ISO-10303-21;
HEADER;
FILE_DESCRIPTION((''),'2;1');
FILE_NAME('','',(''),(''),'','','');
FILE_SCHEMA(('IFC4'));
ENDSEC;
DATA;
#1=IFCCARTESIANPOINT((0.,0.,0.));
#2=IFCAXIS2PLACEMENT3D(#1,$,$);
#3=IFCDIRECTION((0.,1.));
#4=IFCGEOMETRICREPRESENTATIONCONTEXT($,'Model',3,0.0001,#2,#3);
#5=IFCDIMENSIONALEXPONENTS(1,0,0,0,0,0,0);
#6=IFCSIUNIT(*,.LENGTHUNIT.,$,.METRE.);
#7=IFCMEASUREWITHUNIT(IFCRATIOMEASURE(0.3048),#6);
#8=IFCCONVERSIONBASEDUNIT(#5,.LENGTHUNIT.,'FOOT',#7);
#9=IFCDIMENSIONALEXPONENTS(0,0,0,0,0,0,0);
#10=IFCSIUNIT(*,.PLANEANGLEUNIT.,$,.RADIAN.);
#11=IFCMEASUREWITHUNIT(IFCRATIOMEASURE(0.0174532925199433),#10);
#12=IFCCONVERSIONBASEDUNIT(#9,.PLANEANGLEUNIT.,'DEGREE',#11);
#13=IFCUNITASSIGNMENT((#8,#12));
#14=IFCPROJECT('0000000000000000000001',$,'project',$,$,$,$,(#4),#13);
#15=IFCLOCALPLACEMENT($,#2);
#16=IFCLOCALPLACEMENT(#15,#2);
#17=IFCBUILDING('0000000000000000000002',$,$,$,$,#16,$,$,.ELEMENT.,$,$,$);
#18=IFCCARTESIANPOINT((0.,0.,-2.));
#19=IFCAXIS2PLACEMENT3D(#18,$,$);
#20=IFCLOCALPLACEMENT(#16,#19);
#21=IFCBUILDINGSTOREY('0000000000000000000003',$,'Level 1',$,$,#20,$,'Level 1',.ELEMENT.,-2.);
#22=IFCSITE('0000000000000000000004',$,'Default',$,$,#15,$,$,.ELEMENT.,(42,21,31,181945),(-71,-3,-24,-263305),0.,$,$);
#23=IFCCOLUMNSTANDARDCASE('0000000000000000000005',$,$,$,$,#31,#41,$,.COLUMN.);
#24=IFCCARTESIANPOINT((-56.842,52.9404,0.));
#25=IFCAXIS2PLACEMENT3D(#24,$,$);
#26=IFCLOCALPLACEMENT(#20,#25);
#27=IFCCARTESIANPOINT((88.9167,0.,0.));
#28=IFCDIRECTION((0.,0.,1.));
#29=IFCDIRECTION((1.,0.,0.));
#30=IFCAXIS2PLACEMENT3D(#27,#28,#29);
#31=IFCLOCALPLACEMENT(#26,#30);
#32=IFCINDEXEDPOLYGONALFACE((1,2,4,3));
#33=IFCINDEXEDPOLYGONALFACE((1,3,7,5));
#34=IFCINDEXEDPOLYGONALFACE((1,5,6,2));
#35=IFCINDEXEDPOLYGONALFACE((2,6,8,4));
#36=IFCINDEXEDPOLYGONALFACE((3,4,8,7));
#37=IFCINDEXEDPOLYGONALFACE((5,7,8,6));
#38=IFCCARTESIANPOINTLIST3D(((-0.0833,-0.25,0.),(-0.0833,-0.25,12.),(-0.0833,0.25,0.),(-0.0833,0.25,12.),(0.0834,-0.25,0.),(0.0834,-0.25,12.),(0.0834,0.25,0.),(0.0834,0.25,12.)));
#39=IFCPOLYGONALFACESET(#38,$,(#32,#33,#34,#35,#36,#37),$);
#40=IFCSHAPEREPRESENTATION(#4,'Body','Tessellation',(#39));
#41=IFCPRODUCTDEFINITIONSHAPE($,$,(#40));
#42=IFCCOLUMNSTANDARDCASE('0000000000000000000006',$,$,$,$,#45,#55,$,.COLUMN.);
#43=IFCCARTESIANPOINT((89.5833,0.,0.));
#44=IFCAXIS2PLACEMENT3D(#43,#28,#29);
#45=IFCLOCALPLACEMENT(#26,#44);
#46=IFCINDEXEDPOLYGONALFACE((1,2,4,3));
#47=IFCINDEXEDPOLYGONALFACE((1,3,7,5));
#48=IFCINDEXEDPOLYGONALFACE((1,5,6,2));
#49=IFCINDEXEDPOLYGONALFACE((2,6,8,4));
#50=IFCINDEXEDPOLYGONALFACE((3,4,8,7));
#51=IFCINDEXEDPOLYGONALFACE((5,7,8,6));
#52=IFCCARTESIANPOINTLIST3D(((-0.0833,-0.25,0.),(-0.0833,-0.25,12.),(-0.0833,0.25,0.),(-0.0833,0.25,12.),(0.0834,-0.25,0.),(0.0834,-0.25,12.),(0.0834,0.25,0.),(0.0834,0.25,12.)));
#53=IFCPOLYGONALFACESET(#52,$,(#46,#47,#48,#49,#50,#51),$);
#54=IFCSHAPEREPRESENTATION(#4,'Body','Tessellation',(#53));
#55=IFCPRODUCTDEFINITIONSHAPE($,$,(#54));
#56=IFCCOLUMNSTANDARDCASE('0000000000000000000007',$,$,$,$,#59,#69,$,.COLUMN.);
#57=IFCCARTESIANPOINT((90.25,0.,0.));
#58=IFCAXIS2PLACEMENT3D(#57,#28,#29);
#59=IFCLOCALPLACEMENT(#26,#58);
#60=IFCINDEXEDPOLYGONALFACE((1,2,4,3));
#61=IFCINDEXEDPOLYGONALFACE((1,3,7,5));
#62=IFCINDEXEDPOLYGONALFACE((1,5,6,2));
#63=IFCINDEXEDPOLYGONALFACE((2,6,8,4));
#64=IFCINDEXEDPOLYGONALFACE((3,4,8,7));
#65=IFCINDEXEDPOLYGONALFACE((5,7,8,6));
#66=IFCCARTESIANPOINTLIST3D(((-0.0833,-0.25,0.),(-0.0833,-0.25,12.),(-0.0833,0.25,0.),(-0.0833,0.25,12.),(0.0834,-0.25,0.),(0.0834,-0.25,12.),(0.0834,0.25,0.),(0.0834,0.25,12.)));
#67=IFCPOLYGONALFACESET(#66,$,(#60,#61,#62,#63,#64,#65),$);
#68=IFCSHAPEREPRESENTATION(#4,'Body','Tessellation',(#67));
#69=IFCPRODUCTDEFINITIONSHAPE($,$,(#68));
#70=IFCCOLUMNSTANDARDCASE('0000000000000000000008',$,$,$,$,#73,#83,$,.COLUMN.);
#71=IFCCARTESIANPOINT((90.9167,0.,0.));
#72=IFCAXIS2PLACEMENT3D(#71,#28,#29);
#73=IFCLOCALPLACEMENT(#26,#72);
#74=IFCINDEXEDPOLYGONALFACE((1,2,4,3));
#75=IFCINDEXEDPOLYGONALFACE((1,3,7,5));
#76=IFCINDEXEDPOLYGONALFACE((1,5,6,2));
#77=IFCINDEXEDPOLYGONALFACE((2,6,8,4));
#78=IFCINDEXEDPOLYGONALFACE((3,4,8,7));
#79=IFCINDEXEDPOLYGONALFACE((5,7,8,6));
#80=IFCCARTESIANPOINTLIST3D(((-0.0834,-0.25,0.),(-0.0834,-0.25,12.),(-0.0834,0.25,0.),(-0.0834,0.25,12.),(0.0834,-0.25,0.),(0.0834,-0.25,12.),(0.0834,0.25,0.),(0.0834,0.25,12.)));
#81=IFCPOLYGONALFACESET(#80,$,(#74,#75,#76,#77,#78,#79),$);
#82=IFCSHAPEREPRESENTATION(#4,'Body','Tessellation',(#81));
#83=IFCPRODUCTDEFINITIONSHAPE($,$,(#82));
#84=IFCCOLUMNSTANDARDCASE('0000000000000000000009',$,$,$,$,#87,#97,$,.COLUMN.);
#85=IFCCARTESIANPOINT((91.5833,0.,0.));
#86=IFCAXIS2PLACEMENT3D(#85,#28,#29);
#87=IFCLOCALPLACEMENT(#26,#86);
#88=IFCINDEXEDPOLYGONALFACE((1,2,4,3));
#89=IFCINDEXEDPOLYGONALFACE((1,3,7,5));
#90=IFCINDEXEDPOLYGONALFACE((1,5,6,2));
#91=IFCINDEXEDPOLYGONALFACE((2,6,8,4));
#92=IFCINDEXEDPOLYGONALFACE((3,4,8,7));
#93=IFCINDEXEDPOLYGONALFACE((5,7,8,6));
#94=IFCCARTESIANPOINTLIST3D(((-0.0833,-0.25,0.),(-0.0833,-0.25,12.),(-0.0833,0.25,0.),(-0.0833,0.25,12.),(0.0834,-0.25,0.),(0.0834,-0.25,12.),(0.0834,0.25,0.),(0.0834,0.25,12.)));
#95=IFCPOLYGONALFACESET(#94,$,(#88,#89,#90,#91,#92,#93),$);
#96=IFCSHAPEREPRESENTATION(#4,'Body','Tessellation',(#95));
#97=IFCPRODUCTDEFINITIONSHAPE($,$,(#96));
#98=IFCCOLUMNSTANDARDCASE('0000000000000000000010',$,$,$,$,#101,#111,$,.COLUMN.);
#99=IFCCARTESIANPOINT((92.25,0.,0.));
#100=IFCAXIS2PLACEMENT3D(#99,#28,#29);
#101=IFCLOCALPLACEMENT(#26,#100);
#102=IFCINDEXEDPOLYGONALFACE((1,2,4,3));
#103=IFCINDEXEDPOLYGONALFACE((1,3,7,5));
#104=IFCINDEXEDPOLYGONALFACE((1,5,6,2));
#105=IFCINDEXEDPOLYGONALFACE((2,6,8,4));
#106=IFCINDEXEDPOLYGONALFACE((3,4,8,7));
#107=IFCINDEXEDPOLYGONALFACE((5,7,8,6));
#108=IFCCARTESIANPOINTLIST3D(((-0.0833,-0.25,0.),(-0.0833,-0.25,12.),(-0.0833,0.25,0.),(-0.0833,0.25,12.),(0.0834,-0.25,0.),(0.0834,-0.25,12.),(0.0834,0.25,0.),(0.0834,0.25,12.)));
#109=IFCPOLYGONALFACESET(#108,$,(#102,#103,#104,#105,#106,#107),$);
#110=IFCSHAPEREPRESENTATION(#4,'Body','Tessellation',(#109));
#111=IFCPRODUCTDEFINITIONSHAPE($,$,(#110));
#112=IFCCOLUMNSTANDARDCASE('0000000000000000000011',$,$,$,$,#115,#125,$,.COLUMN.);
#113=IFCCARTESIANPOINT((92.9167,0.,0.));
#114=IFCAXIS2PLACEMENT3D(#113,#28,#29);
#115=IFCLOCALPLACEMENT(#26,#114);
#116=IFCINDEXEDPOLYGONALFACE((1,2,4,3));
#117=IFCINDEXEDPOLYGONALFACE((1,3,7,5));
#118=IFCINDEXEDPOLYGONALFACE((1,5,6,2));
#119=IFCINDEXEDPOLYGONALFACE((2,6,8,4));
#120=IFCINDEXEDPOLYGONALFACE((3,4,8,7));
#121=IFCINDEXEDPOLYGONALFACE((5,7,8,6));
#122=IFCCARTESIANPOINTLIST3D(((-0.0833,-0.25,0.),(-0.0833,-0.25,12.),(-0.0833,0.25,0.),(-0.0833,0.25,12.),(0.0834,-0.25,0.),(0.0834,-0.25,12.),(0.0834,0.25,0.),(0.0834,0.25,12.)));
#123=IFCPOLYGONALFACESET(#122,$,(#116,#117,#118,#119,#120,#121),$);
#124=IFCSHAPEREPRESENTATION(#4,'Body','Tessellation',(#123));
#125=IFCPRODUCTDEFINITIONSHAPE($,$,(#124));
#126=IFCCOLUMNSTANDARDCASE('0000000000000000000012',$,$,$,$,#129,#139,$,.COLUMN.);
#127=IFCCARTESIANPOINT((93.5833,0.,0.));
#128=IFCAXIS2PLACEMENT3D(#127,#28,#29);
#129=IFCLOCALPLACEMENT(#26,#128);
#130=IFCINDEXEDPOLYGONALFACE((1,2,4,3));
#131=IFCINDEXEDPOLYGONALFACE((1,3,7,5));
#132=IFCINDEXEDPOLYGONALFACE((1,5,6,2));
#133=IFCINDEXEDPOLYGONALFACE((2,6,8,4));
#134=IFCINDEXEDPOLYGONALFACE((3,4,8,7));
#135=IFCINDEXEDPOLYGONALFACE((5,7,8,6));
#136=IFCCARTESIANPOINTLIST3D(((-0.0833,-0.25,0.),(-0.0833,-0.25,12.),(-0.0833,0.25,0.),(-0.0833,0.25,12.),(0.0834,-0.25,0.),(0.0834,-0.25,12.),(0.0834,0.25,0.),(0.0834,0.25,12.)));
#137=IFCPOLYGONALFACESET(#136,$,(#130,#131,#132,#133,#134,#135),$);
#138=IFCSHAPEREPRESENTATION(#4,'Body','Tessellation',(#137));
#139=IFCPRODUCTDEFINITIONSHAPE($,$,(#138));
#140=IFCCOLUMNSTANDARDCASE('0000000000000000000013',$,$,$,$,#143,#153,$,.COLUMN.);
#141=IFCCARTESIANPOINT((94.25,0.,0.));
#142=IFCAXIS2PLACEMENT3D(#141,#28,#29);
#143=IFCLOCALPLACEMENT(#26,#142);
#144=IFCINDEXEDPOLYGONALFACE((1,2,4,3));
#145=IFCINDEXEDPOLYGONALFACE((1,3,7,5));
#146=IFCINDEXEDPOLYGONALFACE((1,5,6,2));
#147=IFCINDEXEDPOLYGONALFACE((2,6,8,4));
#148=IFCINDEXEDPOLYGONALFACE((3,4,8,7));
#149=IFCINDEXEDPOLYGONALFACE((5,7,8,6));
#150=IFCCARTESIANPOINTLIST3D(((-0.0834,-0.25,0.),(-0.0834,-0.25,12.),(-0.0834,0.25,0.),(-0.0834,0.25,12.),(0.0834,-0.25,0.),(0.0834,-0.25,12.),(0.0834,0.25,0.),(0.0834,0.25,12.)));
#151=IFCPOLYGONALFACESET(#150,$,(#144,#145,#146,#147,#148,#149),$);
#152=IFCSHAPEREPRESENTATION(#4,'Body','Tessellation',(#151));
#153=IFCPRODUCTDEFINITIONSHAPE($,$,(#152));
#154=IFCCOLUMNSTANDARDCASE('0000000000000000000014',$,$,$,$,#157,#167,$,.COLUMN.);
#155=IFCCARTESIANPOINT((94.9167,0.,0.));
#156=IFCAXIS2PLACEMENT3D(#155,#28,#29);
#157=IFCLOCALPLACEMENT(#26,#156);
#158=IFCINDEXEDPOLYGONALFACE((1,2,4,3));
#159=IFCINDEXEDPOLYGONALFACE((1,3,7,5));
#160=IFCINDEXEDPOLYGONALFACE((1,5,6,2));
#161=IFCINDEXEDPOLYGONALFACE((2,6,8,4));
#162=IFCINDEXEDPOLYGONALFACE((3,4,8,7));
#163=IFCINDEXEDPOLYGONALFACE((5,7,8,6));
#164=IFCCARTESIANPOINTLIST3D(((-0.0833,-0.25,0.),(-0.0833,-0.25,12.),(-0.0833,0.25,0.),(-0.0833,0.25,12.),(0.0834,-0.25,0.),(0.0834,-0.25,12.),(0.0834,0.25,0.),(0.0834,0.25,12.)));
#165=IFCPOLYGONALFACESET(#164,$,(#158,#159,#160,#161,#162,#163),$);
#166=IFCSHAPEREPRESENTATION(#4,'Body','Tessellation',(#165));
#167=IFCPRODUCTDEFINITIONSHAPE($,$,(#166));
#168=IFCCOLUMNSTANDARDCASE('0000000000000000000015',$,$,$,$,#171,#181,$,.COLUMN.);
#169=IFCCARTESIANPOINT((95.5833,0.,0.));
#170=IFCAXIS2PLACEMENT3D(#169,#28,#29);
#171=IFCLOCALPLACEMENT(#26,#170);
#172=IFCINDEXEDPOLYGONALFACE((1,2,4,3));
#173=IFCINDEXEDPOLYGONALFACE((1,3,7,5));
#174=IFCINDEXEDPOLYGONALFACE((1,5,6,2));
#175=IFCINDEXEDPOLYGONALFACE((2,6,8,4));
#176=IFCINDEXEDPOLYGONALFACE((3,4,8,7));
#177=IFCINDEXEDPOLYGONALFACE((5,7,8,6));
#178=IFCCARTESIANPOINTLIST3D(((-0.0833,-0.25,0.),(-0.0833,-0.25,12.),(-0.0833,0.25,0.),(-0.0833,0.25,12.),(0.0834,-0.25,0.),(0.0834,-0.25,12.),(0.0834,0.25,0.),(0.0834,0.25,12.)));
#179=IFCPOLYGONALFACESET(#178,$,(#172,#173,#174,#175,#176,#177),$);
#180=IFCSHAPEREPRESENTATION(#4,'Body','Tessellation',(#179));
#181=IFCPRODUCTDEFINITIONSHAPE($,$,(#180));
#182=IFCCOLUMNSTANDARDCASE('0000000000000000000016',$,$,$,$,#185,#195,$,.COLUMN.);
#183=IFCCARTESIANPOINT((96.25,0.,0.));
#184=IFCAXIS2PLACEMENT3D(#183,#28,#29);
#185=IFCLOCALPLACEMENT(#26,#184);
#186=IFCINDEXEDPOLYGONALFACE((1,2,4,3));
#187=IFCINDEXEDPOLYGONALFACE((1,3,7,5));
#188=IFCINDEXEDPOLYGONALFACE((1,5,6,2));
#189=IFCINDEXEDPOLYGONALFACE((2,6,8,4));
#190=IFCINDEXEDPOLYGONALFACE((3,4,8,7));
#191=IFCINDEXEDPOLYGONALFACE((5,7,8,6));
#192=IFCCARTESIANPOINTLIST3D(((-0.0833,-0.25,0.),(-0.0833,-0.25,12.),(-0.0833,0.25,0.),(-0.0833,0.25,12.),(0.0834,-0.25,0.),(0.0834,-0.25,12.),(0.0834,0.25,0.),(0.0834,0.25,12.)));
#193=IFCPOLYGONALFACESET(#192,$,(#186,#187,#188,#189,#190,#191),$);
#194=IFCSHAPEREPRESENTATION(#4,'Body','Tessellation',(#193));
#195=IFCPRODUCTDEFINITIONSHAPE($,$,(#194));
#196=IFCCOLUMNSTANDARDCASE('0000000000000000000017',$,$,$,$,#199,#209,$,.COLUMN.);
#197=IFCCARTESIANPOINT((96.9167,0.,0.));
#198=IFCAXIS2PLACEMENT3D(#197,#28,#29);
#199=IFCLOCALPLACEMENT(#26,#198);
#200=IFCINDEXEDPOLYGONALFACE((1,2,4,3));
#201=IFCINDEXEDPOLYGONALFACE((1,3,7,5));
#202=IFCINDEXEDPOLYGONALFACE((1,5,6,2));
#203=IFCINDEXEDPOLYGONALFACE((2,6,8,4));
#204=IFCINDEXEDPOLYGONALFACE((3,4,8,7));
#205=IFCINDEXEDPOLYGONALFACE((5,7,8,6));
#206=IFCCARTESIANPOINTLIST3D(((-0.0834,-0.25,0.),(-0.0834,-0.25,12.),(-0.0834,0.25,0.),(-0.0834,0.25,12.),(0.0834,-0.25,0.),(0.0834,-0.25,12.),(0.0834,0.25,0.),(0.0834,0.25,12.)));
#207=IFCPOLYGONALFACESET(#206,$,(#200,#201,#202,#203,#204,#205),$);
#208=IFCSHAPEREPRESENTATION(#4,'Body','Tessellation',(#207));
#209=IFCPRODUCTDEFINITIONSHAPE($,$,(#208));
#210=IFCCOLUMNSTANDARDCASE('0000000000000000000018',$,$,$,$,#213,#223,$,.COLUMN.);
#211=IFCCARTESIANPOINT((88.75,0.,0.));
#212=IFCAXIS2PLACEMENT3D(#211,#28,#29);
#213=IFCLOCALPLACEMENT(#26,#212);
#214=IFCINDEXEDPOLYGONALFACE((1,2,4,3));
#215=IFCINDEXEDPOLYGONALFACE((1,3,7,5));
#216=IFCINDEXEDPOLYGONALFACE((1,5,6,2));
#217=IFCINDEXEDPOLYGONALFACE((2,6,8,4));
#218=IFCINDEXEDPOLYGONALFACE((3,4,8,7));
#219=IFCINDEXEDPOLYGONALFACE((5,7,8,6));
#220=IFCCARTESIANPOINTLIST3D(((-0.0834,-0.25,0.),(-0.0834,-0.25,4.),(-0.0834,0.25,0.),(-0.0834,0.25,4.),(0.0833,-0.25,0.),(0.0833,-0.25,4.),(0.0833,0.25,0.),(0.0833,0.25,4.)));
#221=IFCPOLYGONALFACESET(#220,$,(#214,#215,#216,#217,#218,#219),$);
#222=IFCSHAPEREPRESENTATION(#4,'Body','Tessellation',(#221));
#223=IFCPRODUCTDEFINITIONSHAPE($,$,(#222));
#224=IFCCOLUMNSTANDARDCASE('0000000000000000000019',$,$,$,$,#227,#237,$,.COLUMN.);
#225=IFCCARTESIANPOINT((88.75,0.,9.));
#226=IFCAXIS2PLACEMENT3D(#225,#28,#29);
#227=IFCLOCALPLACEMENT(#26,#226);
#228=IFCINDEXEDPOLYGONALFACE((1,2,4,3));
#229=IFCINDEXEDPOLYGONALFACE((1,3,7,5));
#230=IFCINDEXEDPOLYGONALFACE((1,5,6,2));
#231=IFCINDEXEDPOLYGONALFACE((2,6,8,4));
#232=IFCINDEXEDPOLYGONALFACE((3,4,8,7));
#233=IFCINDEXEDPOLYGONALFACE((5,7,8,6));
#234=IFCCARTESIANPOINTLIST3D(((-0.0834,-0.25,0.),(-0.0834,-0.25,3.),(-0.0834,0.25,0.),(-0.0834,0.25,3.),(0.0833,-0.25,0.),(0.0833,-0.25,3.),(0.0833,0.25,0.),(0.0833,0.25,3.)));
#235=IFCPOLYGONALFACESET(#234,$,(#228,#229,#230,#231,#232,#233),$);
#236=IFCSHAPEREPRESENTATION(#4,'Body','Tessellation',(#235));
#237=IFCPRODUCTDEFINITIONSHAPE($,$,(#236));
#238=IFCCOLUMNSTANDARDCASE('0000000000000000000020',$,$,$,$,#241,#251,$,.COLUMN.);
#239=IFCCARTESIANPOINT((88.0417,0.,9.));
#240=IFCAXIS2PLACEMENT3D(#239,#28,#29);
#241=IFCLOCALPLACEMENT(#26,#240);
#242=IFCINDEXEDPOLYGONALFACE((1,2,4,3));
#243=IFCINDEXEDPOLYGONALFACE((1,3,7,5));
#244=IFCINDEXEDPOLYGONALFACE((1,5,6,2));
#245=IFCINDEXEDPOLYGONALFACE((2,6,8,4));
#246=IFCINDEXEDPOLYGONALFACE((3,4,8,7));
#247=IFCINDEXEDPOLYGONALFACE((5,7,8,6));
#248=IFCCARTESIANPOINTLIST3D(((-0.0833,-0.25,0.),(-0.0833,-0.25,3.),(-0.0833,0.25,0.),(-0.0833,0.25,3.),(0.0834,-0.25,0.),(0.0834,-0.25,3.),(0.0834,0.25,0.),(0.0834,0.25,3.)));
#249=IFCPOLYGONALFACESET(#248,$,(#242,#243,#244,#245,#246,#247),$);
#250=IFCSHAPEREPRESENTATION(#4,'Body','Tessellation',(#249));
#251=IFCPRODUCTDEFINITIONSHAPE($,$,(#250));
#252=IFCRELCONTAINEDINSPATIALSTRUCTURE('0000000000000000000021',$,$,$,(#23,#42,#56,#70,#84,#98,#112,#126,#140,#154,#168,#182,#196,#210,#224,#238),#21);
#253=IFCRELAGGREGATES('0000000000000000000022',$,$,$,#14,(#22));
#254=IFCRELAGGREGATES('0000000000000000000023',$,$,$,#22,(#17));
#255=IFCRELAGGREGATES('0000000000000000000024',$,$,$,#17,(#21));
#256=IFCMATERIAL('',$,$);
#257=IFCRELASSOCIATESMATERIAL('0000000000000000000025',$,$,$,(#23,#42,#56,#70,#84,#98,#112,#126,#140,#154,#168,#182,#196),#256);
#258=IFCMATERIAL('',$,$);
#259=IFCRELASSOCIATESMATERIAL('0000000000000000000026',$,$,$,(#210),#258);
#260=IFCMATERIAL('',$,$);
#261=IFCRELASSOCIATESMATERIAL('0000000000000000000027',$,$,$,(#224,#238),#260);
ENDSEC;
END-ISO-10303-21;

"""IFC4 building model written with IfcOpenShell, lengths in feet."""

from ifc_helpers import new_model, entity, si_unit, converted_unit, direction, frame, origin, place, context, project, spatial, rectangle, extrude, material, element, save


model = new_model("IFC4")

# Units and contexts
model_context = context("Model", 3, precision=0.0001, world=origin(), true_north=direction((0.0, 1.0)))
ifc_project = project(units=[converted_unit("LENGTHUNIT", "FOOT", entity("IfcRatioMeasure", 0.3048), si_unit("LENGTHUNIT", "METRE"), dimensions=[1, 0, 0, 0, 0, 0, 0]), converted_unit("PLANEANGLEUNIT", "DEGREE", entity("IfcRatioMeasure", 0.0174532925199433), si_unit("PLANEANGLEUNIT", "RADIAN"), dimensions=[0, 0, 0, 0, 0, 0, 0])], contexts=[model_context])

# Site, building, storey
site_placement = place(None, origin())
site = spatial("IfcSite", under=ifc_project, at=site_placement, Name="Default", CompositionType="ELEMENT", RefLatitude=(42, 21, 31, 181945), RefLongitude=(-71, -3, -24, -263305), RefElevation=0.0)
building_placement = place(site_placement, origin())
building = spatial("IfcBuilding", under=site, at=building_placement, CompositionType="ELEMENT")
storey_placement = place(building_placement, frame((0.0, 0.0, -2.0)))
storey = spatial("IfcBuildingStorey", under=building, at=storey_placement, Name="Level 1", LongName="Level 1", CompositionType="ELEMENT", Elevation=-2.0)

# Columns
ifc_material_1 = material(Name="")
placement = place(storey_placement, frame((-56.842, 52.9404, 0.0)))
for number, where, z_axis, x_axis in (
    (1, (88.9167, 0.0, 0.0), (0.0, 0.0, 1.0), (1.0, 0.0, 0.0)),
    (2, (89.5833, 0.0, 0.0), (0.0, 0.0, 1.0), (1.0, 0.0, 0.0)),
    (3, (90.25, 0.0, 0.0), (0.0, 0.0, 1.0), (1.0, 0.0, 0.0)),
    (4, (90.9167, 0.0, 0.0), (0.0, 0.0, 1.0), (1.0, 0.0, 0.0)),
    (5, (91.5833, 0.0, 0.0), (0.0, 0.0, 1.0), (1.0, 0.0, 0.0)),
    (6, (92.25, 0.0, 0.0), (0.0, 0.0, 1.0), (1.0, 0.0, 0.0)),
    (7, (92.9167, 0.0, 0.0), (0.0, 0.0, 1.0), (1.0, 0.0, 0.0)),
    (8, (93.5833, 0.0, 0.0), (0.0, 0.0, 1.0), (1.0, 0.0, 0.0)),
    (9, (94.25, 0.0, 0.0), (0.0, 0.0, 1.0), (1.0, 0.0, 0.0)),
    (10, (94.9167, 0.0, 0.0), (0.0, 0.0, 1.0), (1.0, 0.0, 0.0)),
    (11, (95.5833, 0.0, 0.0), (0.0, 0.0, 1.0), (1.0, 0.0, 0.0)),
    (12, (96.25, 0.0, 0.0), (0.0, 0.0, 1.0), (1.0, 0.0, 0.0)),
    (13, (96.9167, 0.0, 0.0), (0.0, 0.0, 1.0), (1.0, 0.0, 0.0)),
):
    element("IfcColumnStandardCase", number, at=place(placement, frame(where, z_axis=z_axis, x_axis=x_axis)), inside=storey, material=ifc_material_1, PredefinedType="COLUMN", context=model_context, shape_type="SweptSolid", body=[
        extrude(rectangle(XDim=0.1667, YDim=0.5), origin(), (0.0, 0.0, 1.0), 12.0),
    ])
ifc_material_2 = material(Name="")
for number, where, z_axis, x_axis in (
    (14, (88.75, 0.0, 0.0), (0.0, 0.0, 1.0), (1.0, 0.0, 0.0)),
):
    element("IfcColumnStandardCase", number, at=place(placement, frame(where, z_axis=z_axis, x_axis=x_axis)), inside=storey, material=ifc_material_2, PredefinedType="COLUMN", context=model_context, shape_type="SweptSolid", body=[
        extrude(rectangle(XDim=0.1667, YDim=0.5), origin(), (0.0, 0.0, 1.0), 4.0),
    ])
ifc_material_3 = material(Name="")
for number, where, z_axis, x_axis in (
    (15, (88.75, 0.0, 9.0), (0.0, 0.0, 1.0), (1.0, 0.0, 0.0)),
    (16, (88.0417, 0.0, 9.0), (0.0, 0.0, 1.0), (1.0, 0.0, 0.0)),
):
    element("IfcColumnStandardCase", number, at=place(placement, frame(where, z_axis=z_axis, x_axis=x_axis)), inside=storey, material=ifc_material_3, PredefinedType="COLUMN", context=model_context, shape_type="SweptSolid", body=[
        extrude(rectangle(XDim=0.1667, YDim=0.5), origin(), (0.0, 0.0, 1.0), 3.0),
    ])

save(model, "model.ifc")
